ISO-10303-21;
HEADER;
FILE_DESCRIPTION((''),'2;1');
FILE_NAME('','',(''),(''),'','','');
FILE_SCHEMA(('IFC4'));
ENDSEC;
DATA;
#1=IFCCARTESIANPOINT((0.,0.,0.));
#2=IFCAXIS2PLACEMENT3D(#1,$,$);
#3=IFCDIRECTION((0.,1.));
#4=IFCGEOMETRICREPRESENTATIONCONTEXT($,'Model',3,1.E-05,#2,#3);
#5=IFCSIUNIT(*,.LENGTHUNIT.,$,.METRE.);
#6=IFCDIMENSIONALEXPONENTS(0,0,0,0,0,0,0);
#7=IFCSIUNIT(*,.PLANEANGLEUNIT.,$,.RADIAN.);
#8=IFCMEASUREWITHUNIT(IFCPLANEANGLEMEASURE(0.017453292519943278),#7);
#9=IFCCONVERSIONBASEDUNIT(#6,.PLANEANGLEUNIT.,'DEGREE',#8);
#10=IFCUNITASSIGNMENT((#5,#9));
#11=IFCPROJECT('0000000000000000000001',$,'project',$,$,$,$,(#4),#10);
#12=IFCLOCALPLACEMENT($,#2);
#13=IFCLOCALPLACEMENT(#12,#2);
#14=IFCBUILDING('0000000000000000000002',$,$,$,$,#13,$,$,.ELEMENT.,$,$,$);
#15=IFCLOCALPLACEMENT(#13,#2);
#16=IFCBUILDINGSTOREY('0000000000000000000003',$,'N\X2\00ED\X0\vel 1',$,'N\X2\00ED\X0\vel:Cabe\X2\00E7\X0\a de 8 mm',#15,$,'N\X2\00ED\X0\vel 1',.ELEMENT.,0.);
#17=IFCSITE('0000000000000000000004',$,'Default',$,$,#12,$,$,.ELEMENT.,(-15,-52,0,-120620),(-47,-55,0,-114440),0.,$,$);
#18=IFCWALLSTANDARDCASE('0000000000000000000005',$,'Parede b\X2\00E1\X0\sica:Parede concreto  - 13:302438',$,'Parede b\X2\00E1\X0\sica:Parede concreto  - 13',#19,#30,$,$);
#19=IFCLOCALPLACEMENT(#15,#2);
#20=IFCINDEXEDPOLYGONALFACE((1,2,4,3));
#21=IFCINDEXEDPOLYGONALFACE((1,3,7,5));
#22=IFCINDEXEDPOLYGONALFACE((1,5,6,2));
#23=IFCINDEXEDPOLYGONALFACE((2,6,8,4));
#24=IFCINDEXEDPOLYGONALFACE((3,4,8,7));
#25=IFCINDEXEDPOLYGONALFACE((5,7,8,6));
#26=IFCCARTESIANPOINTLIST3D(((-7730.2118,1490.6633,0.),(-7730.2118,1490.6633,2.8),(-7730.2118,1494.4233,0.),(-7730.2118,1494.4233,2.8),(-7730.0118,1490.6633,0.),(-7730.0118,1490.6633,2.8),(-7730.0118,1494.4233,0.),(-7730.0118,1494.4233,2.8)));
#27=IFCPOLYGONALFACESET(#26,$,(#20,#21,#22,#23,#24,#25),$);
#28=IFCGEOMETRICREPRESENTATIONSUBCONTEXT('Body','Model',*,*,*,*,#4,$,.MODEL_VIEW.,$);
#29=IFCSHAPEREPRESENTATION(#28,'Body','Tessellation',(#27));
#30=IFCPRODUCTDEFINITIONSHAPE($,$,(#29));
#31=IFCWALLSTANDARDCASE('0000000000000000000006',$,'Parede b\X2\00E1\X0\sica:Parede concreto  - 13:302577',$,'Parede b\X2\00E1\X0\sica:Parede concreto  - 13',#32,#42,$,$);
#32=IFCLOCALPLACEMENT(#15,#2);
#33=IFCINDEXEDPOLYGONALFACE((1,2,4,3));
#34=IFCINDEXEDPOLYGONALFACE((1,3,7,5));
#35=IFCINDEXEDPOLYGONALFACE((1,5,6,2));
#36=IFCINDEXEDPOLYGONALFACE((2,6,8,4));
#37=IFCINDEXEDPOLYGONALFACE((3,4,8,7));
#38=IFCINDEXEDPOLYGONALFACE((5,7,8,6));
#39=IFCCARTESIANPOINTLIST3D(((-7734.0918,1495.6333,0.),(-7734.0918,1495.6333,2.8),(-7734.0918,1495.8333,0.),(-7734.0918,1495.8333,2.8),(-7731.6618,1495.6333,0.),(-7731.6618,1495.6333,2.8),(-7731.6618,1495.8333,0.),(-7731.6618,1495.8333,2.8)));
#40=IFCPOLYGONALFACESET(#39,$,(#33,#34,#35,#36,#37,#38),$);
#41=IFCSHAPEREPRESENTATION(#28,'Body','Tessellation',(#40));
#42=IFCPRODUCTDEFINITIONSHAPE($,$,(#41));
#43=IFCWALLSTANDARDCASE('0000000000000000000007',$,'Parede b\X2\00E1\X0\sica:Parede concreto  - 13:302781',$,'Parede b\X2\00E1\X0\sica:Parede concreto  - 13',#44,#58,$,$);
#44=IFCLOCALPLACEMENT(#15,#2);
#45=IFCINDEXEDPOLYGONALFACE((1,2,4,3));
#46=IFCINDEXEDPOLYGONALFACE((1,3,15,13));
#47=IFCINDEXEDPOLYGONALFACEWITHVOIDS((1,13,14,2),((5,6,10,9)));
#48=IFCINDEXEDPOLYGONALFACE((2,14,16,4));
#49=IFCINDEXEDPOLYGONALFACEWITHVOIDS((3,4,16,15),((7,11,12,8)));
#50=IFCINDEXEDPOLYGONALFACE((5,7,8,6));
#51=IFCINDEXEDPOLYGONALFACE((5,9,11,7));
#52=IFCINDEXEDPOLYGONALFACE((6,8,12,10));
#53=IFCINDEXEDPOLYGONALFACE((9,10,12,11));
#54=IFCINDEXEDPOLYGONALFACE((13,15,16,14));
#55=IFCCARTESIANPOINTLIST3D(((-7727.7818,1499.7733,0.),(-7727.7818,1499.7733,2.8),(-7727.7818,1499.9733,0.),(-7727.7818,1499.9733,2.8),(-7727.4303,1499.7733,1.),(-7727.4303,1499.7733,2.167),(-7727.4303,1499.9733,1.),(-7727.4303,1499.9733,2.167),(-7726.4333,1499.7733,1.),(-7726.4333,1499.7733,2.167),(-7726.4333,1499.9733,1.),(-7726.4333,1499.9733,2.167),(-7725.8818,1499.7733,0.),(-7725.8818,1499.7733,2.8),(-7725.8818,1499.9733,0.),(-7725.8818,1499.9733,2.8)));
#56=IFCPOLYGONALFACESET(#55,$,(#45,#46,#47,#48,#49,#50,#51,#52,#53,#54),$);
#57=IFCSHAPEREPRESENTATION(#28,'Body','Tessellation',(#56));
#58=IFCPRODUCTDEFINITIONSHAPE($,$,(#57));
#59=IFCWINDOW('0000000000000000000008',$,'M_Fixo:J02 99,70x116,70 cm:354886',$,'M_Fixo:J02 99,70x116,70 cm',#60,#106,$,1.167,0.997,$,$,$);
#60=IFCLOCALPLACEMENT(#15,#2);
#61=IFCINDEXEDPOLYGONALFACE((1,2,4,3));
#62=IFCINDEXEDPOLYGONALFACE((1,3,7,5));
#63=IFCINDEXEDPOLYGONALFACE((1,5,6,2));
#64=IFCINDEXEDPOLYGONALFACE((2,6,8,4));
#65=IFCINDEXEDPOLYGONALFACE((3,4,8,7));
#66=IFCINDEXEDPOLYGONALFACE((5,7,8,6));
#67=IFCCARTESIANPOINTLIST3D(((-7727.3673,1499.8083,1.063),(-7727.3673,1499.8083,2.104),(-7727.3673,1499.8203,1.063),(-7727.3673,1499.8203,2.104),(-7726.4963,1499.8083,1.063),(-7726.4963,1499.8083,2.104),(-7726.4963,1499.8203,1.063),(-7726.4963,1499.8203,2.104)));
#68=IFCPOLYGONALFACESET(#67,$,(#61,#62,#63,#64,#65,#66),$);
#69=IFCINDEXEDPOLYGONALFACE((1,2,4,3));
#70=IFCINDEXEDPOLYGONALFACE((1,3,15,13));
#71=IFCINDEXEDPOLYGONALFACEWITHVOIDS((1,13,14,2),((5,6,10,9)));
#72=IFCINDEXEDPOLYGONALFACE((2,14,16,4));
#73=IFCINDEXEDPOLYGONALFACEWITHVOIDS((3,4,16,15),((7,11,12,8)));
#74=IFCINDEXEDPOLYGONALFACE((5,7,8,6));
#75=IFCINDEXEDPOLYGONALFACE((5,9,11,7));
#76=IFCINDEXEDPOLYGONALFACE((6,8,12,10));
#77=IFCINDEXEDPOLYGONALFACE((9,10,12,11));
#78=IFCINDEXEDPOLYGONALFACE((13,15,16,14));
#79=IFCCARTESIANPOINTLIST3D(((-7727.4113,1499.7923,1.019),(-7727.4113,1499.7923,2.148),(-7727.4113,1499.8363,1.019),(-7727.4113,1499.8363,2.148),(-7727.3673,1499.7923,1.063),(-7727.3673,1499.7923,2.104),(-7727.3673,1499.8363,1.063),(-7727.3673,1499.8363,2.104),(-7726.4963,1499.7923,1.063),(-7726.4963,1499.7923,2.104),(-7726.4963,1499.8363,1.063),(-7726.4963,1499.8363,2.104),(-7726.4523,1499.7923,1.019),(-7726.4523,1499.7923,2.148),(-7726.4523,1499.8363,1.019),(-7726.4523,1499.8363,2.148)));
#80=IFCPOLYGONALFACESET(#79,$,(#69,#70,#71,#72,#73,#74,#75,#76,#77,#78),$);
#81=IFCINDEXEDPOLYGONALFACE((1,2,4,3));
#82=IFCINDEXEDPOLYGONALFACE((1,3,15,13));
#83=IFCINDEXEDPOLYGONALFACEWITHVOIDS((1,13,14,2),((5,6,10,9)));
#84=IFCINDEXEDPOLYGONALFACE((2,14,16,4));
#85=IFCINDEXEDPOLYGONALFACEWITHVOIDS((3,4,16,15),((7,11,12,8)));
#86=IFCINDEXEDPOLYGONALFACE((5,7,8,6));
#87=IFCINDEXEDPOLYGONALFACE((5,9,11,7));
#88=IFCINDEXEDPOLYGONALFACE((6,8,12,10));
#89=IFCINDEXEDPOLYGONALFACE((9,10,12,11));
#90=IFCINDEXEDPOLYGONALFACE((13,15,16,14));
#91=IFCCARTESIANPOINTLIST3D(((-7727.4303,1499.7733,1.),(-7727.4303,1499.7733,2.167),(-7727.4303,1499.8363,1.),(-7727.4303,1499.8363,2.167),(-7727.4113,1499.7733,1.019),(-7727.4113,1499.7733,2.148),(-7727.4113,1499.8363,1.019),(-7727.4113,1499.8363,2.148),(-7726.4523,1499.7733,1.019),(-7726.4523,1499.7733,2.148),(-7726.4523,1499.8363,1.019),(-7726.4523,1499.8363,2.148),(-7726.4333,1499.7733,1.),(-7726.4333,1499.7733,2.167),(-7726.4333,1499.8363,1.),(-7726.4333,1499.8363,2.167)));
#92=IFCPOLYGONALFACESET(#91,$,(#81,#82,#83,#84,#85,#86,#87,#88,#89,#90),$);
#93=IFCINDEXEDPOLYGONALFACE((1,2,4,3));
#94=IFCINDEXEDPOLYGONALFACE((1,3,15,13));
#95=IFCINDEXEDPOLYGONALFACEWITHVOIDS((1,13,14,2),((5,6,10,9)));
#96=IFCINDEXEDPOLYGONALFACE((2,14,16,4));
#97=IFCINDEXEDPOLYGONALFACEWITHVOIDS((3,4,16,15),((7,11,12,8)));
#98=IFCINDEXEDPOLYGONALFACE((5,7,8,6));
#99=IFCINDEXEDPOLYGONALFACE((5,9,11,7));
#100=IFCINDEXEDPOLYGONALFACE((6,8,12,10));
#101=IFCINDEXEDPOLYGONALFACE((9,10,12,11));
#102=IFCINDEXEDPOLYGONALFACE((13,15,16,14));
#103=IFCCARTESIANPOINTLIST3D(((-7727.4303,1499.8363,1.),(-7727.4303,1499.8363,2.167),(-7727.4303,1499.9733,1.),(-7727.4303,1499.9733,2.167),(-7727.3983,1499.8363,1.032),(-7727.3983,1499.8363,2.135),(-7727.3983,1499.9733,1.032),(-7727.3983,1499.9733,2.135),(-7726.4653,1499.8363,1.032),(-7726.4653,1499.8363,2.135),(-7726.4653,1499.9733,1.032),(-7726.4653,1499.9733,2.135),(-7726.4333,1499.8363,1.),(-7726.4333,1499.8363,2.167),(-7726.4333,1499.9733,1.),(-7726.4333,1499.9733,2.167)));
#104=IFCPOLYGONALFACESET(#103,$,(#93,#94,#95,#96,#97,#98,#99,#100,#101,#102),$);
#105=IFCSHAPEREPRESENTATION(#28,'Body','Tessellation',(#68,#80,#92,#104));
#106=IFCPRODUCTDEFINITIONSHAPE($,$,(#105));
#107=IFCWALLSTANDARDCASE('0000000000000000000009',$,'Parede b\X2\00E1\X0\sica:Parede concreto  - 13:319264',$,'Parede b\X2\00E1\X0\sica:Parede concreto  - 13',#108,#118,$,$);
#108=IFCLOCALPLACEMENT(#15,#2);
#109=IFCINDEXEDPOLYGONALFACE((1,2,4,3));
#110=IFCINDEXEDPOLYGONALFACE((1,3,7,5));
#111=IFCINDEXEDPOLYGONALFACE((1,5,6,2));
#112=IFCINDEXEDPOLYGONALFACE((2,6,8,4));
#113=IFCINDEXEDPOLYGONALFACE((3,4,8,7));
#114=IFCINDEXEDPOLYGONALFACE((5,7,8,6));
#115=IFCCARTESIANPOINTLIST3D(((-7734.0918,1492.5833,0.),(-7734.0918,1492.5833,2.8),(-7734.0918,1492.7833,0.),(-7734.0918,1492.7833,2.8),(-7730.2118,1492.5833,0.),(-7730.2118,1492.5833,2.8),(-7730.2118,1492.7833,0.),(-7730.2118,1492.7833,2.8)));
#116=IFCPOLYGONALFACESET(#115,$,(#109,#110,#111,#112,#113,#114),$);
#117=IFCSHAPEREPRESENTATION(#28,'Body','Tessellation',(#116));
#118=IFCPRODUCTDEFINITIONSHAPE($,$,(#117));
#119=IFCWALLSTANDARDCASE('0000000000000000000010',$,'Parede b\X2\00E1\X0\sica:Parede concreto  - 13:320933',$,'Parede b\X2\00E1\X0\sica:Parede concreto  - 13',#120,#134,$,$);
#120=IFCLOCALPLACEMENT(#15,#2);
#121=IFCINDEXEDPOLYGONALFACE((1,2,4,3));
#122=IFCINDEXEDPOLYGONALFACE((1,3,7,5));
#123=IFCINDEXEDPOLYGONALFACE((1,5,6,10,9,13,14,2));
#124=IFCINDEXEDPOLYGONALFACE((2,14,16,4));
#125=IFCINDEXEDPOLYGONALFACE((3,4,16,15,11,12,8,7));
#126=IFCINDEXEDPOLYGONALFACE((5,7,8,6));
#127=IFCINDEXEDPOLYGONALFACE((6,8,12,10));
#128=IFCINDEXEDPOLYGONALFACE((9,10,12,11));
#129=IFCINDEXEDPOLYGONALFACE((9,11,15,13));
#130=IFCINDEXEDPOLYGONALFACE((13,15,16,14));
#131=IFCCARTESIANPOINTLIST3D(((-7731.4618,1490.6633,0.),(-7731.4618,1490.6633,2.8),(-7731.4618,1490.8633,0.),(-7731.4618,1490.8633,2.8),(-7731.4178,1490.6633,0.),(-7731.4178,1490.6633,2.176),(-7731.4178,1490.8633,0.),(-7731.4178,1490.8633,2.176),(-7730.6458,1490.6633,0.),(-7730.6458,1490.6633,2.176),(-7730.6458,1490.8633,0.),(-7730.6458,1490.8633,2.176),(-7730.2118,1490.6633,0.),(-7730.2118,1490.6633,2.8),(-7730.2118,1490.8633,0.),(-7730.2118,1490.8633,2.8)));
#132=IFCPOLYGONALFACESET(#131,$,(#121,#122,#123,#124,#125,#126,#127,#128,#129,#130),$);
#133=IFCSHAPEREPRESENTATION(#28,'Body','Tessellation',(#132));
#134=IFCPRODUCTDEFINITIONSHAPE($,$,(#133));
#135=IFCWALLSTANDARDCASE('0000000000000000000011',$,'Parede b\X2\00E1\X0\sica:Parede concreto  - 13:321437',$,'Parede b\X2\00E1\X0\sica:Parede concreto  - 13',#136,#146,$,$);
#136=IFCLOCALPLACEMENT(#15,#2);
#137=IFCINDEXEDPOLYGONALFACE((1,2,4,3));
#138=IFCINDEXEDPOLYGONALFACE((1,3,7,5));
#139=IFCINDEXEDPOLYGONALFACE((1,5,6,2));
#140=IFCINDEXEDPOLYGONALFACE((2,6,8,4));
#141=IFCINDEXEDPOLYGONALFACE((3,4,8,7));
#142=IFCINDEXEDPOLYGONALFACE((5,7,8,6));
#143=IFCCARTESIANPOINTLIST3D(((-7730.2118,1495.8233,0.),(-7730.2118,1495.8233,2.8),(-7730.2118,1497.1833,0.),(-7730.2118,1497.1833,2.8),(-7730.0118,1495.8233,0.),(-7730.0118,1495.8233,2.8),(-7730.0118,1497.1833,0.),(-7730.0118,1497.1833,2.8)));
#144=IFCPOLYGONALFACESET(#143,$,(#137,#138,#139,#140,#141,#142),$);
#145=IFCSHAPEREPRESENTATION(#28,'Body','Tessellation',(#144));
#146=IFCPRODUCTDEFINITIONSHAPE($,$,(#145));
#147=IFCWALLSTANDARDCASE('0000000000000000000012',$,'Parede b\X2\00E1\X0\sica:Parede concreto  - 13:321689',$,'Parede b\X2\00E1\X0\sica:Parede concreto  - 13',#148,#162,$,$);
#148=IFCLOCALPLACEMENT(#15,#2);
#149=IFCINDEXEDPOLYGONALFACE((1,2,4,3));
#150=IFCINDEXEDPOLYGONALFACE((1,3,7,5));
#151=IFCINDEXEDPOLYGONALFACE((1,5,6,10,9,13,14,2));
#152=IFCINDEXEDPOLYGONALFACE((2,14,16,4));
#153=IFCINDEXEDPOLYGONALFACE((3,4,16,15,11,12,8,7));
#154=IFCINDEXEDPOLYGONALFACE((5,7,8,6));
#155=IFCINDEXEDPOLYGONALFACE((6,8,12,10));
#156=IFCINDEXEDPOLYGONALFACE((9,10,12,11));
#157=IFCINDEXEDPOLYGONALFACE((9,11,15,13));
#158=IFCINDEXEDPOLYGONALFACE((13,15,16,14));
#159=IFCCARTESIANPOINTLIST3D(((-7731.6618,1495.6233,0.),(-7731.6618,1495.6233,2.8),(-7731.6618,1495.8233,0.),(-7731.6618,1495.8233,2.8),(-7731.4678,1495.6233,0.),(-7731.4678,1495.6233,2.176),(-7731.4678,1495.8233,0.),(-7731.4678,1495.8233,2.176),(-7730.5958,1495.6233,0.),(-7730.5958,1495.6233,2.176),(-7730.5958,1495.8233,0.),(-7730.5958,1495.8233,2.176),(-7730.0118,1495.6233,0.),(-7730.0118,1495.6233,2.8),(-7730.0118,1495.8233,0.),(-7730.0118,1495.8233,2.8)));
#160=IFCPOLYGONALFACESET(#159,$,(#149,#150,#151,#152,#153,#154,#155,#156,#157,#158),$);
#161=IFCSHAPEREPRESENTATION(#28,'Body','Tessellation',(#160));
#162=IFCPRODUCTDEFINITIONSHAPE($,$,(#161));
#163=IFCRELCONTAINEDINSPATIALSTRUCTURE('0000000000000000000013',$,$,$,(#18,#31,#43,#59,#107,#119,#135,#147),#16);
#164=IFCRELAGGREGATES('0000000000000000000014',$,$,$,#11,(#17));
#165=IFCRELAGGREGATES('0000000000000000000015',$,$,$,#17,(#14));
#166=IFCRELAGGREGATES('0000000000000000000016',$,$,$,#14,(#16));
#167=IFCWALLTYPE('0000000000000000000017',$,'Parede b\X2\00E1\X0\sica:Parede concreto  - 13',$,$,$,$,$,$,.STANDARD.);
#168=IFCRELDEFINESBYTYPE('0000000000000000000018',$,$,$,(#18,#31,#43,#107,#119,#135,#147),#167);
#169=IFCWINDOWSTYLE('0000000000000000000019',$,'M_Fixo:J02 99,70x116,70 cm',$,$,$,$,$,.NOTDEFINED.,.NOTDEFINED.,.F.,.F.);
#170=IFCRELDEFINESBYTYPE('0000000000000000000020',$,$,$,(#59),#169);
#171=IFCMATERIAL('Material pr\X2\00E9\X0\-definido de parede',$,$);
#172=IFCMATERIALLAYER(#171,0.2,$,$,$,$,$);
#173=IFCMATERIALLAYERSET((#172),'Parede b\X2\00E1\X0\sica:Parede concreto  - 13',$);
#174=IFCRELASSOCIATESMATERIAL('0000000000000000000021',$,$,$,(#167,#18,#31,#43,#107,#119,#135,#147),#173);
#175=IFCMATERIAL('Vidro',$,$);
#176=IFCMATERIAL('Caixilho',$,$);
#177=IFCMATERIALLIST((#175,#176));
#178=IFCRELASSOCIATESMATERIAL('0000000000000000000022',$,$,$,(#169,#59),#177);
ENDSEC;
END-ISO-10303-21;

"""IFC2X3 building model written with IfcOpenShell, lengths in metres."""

from ifc_helpers import new_model, entity, si_unit, converted_unit, direction, frame, frame_2d, origin, place, context, subcontext, project, spatial, polyline, rectangle, outline, extrude, source, transform, mapped, material, material_list, layer, layer_set, layer_usage, type_object, type_shapes, element, fill, save


model = new_model("IFC2X3")

# Units and contexts
model_context = context("Model", 3, precision=1e-05, world=origin(), true_north=direction((0.0, 1.0)))
body_context = subcontext(model_context, "Body", "Model", "MODEL_VIEW")
ifc_project = project(units=[si_unit("LENGTHUNIT", "METRE"), converted_unit("PLANEANGLEUNIT", "DEGREE", entity("IfcPlaneAngleMeasure", 0.017453292519943278), si_unit("PLANEANGLEUNIT", "RADIAN"), dimensions=[0, 0, 0, 0, 0, 0, 0])], contexts=[model_context])

# Site, building, storey
site_placement = place(None, origin())
site = spatial("IfcSite", under=ifc_project, at=site_placement, Name="Default", CompositionType="ELEMENT", RefLatitude=(-15, -52, 0, -120620), RefLongitude=(-47, -55, 0, -114440), RefElevation=0.0)
building_placement = place(site_placement, origin())
building = spatial("IfcBuilding", under=site, at=building_placement, CompositionType="ELEMENT")
storey_placement = place(building_placement, origin())
storey = spatial("IfcBuildingStorey", under=building, at=storey_placement, Name="Nível 1", ObjectType="Nível:Cabeça de 8 mm", LongName="Nível 1", CompositionType="ELEMENT", Elevation=0.0)

# Shared definitions
ifc_material_1 = material(Name="Material pré-definido de parede")
ifc_layer = layer(ifc_material_1, 0.2)
ifc_layer_set = layer_set([ifc_layer], Name="Parede básica:Parede concreto  - 13")
wall_type = type_object("IfcWallType", Name="Parede básica:Parede concreto  - 13", PredefinedType="STANDARD", material=ifc_layer_set)
ifc_material_2 = material(Name="Vidro")
ifc_material_3 = material(Name="Caixilho")
ifc_material_list = material_list([ifc_material_2, ifc_material_3])

# Walls
ifc_layer_usage_1 = layer_usage(ifc_layer_set, "AXIS2", "POSITIVE", -0.1)
wall_1_placement = place(storey_placement, frame((-7730.1118, 1494.4233, 0.0), z_axis=(0.0, 0.0, 1.0), x_axis=(0.0, -1.0, 0.0)))
element("IfcWallStandardCase", 1, at=wall_1_placement, inside=storey, type_object=wall_type, material=ifc_layer_usage_1, Name="Parede básica:Parede concreto  - 13:302438", ObjectType="Parede básica:Parede concreto  - 13", context=body_context, shape_type="SweptSolid", body=[
    extrude(rectangle(XDim=3.76, YDim=0.2, at=frame_2d((1.88, 0.0), x_axis=(-1.0, 0.0))), origin(), (0.0, 0.0, 1.0), 2.8),
])
ifc_layer_usage_2 = layer_usage(ifc_layer_set, "AXIS2", "NEGATIVE", 0.1)
wall_2_placement = place(storey_placement, frame((-7731.6618, 1495.7333, 0.0), z_axis=(0.0, 0.0, 1.0), x_axis=(-1.0, 0.0, 0.0)))
element("IfcWallStandardCase", 2, at=wall_2_placement, inside=storey, type_object=wall_type, material=ifc_layer_usage_2, Name="Parede básica:Parede concreto  - 13:302577", ObjectType="Parede básica:Parede concreto  - 13", context=body_context, shape_type="SweptSolid", body=[
    extrude(rectangle(XDim=2.43, YDim=0.2, at=frame_2d((1.215, 0.0), x_axis=(-1.0, 0.0))), origin(), (0.0, 0.0, 1.0), 2.8),
])

# Wall, opening, window
ifc_layer_usage_3 = layer_usage(ifc_layer_set, "AXIS2", "POSITIVE", -0.1)
wall_3_placement = place(storey_placement, frame((-7727.7818, 1499.8733, 0.0)))
wall_3 = element("IfcWallStandardCase", 3, at=wall_3_placement, inside=storey, type_object=wall_type, material=ifc_layer_usage_3, Name="Parede básica:Parede concreto  - 13:302781", ObjectType="Parede básica:Parede concreto  - 13", context=body_context, shape_type="SweptSolid", body=[
    extrude(rectangle(XDim=1.9, YDim=0.2, at=frame_2d((0.95, 0.0), x_axis=(-1.0, 0.0))), origin(), (0.0, 0.0, 1.0), 2.8),
])
opening_1_placement = place(wall_3_placement, frame((1.3485, 0.1, 1.0)))
opening_1 = element("IfcOpeningElement", 4, at=opening_1_placement, cuts=wall_3, ObjectType="Opening", context=body_context, shape_type="SweptSolid", body=[
    extrude(rectangle(XDim=1.167, YDim=0.997, at=frame_2d((0.5835, 0.4985), x_axis=(1.0, 0.0))), frame((0.0, 0.0, 0.0), z_axis=(0.0, -1.0, 0.0), x_axis=(0.0, 0.0, 1.0)), (0.0, 0.0, 1.0), 0.2),
])
window_style_1 = type_object("IfcWindowStyle", Name="M_Fixo:J02 99,70x116,70 cm", ConstructionType="NOTDEFINED", OperationType="NOTDEFINED", ParameterTakesPrecedence=False, Sizeable=False, material=ifc_material_list)
shared_shape_1 = source(origin(), body_context, "Body", "SweptSolid", [
    extrude(rectangle(XDim=0.012, YDim=0.871, at=frame_2d((0.0, 0.0), x_axis=(1.0, 0.0))), frame((0.4985, 0.159, 0.063), z_axis=(0.0, 0.0, 1.0), x_axis=(0.0, -1.0, 0.0)), (0.0, 0.0, 1.0), 1.041),
    extrude(outline(polyline([(-0.4795, -0.5645), (0.4795, -0.5645), (0.4795, 0.5645), (-0.4795, 0.5645), (-0.4795, -0.5645)]), holes=[polyline([(-0.4355, -0.5205), (-0.4355, 0.5205), (0.4355, 0.5205), (0.4355, -0.5205), (-0.4355, -0.5205)])]), frame((0.4985, 0.137, 0.5835), z_axis=(0.0, 1.0, 0.0), x_axis=(1.0, 0.0, 0.0)), (0.0, 0.0, 1.0), 0.044),
    extrude(outline(polyline([(-0.4985, -0.5835), (0.4985, -0.5835), (0.4985, 0.5835), (-0.4985, 0.5835), (-0.4985, -0.5835)]), holes=[polyline([(-0.4795, -0.5645), (-0.4795, 0.5645), (0.4795, 0.5645), (0.4795, -0.5645), (-0.4795, -0.5645)])]), frame((0.4985, 0.137, 0.5835), z_axis=(0.0, 1.0, 0.0), x_axis=(1.0, 0.0, 0.0)), (0.0, 0.0, 1.0), 0.063),
    extrude(outline(polyline([(-0.4985, -0.5835), (0.4985, -0.5835), (0.4985, 0.5835), (-0.4985, 0.5835), (-0.4985, -0.5835)]), holes=[polyline([(-0.4665, -0.5515), (-0.4665, 0.5515), (0.4665, 0.5515), (0.4665, -0.5515), (-0.4665, -0.5515)])]), frame((0.4985, 0.0, 0.5835), z_axis=(0.0, 1.0, 0.0), x_axis=(1.0, 0.0, 0.0)), (0.0, 0.0, 1.0), 0.137),
])
type_shapes(window_style_1, [shared_shape_1])
window_1_placement = place(opening_1_placement, frame((0.0, 0.0, 0.0), z_axis=(0.0, 0.0, 1.0), x_axis=(-1.0, 0.0, 0.0)))
window_1 = element("IfcWindow", 5, at=window_1_placement, inside=storey, type_object=window_style_1, material=ifc_material_list, Name="M_Fixo:J02 99,70x116,70 cm:354886", ObjectType="M_Fixo:J02 99,70x116,70 cm", OverallHeight=1.167, OverallWidth=0.997, context=body_context, shape_type="MappedRepresentation", body=[
    mapped(shared_shape_1, transform((0.0, 0.0, 0.0), scale=1.0)),
])
fill(opening_1, window_1)

# Wall
ifc_layer_usage_4 = layer_usage(ifc_layer_set, "AXIS2", "NEGATIVE", 0.1)
wall_4_placement = place(storey_placement, frame((-7734.0918, 1492.6833, 0.0)))
element("IfcWallStandardCase", 6, at=wall_4_placement, inside=storey, type_object=wall_type, material=ifc_layer_usage_4, Name="Parede básica:Parede concreto  - 13:319264", ObjectType="Parede básica:Parede concreto  - 13", context=body_context, shape_type="SweptSolid", body=[
    extrude(rectangle(XDim=3.88, YDim=0.2, at=frame_2d((1.94, 0.0), x_axis=(-1.0, 0.0))), origin(), (0.0, 0.0, 1.0), 2.8),
])

# Wall, opening
ifc_layer_usage_5 = layer_usage(ifc_layer_set, "AXIS2", "NEGATIVE", 0.1)
wall_5_placement = place(storey_placement, frame((-7730.2118, 1490.7633, 0.0), z_axis=(0.0, 0.0, 1.0), x_axis=(-1.0, 0.0, 0.0)))
wall_5 = element("IfcWallStandardCase", 7, at=wall_5_placement, inside=storey, type_object=wall_type, material=ifc_layer_usage_5, Name="Parede básica:Parede concreto  - 13:320933", ObjectType="Parede básica:Parede concreto  - 13", context=body_context, shape_type="SweptSolid", body=[
    extrude(rectangle(XDim=1.25, YDim=0.2, at=frame_2d((0.625, 0.0), x_axis=(-1.0, 0.0))), origin(), (0.0, 0.0, 1.0), 2.8),
])
opening_2_placement = place(wall_5_placement, origin())
element("IfcOpeningElement", 8, at=opening_2_placement, cuts=wall_5, ObjectType="Opening", context=body_context, shape_type="SweptSolid", body=[
    extrude(rectangle(XDim=2.176, YDim=0.772, at=frame_2d((0.0, 0.0), x_axis=(0.0, 1.0))), frame((0.82, 0.1, 1.088), z_axis=(0.0, -1.0, 0.0), x_axis=(1.0, 0.0, 0.0)), (0.0, 0.0, 1.0), 0.2),
])

# Wall
ifc_layer_usage_6 = layer_usage(ifc_layer_set, "AXIS2", "POSITIVE", -0.1)
wall_6_placement = place(storey_placement, frame((-7730.1118, 1497.1833, 0.0), z_axis=(0.0, 0.0, 1.0), x_axis=(0.0, -1.0, 0.0)))
element("IfcWallStandardCase", 9, at=wall_6_placement, inside=storey, type_object=wall_type, material=ifc_layer_usage_6, Name="Parede básica:Parede concreto  - 13:321437", ObjectType="Parede básica:Parede concreto  - 13", context=body_context, shape_type="SweptSolid", body=[
    extrude(rectangle(XDim=1.36, YDim=0.2, at=frame_2d((0.68, 0.0), x_axis=(-1.0, 0.0))), origin(), (0.0, 0.0, 1.0), 2.8),
])

# Wall, opening
ifc_layer_usage_7 = layer_usage(ifc_layer_set, "AXIS2", "POSITIVE", -0.1)
wall_7_placement = place(storey_placement, frame((-7730.0118, 1495.7233, 0.0), z_axis=(0.0, 0.0, 1.0), x_axis=(-1.0, 0.0, 0.0)))
wall_7 = element("IfcWallStandardCase", 10, at=wall_7_placement, inside=storey, type_object=wall_type, material=ifc_layer_usage_7, Name="Parede básica:Parede concreto  - 13:321689", ObjectType="Parede básica:Parede concreto  - 13", context=body_context, shape_type="SweptSolid", body=[
    extrude(rectangle(XDim=1.65, YDim=0.2, at=frame_2d((0.825, 0.0), x_axis=(-1.0, 0.0))), origin(), (0.0, 0.0, 1.0), 2.8),
])
opening_3_placement = place(wall_7_placement, origin())
element("IfcOpeningElement", 11, at=opening_3_placement, cuts=wall_7, ObjectType="Opening", context=body_context, shape_type="SweptSolid", body=[
    extrude(rectangle(XDim=2.176, YDim=0.872, at=frame_2d((0.0, 0.0), x_axis=(0.0, 1.0))), frame((1.02, 0.1, 1.088), z_axis=(0.0, -1.0, 0.0), x_axis=(1.0, 0.0, 0.0)), (0.0, 0.0, 1.0), 0.2),
])

save(model, "model.ifc")
